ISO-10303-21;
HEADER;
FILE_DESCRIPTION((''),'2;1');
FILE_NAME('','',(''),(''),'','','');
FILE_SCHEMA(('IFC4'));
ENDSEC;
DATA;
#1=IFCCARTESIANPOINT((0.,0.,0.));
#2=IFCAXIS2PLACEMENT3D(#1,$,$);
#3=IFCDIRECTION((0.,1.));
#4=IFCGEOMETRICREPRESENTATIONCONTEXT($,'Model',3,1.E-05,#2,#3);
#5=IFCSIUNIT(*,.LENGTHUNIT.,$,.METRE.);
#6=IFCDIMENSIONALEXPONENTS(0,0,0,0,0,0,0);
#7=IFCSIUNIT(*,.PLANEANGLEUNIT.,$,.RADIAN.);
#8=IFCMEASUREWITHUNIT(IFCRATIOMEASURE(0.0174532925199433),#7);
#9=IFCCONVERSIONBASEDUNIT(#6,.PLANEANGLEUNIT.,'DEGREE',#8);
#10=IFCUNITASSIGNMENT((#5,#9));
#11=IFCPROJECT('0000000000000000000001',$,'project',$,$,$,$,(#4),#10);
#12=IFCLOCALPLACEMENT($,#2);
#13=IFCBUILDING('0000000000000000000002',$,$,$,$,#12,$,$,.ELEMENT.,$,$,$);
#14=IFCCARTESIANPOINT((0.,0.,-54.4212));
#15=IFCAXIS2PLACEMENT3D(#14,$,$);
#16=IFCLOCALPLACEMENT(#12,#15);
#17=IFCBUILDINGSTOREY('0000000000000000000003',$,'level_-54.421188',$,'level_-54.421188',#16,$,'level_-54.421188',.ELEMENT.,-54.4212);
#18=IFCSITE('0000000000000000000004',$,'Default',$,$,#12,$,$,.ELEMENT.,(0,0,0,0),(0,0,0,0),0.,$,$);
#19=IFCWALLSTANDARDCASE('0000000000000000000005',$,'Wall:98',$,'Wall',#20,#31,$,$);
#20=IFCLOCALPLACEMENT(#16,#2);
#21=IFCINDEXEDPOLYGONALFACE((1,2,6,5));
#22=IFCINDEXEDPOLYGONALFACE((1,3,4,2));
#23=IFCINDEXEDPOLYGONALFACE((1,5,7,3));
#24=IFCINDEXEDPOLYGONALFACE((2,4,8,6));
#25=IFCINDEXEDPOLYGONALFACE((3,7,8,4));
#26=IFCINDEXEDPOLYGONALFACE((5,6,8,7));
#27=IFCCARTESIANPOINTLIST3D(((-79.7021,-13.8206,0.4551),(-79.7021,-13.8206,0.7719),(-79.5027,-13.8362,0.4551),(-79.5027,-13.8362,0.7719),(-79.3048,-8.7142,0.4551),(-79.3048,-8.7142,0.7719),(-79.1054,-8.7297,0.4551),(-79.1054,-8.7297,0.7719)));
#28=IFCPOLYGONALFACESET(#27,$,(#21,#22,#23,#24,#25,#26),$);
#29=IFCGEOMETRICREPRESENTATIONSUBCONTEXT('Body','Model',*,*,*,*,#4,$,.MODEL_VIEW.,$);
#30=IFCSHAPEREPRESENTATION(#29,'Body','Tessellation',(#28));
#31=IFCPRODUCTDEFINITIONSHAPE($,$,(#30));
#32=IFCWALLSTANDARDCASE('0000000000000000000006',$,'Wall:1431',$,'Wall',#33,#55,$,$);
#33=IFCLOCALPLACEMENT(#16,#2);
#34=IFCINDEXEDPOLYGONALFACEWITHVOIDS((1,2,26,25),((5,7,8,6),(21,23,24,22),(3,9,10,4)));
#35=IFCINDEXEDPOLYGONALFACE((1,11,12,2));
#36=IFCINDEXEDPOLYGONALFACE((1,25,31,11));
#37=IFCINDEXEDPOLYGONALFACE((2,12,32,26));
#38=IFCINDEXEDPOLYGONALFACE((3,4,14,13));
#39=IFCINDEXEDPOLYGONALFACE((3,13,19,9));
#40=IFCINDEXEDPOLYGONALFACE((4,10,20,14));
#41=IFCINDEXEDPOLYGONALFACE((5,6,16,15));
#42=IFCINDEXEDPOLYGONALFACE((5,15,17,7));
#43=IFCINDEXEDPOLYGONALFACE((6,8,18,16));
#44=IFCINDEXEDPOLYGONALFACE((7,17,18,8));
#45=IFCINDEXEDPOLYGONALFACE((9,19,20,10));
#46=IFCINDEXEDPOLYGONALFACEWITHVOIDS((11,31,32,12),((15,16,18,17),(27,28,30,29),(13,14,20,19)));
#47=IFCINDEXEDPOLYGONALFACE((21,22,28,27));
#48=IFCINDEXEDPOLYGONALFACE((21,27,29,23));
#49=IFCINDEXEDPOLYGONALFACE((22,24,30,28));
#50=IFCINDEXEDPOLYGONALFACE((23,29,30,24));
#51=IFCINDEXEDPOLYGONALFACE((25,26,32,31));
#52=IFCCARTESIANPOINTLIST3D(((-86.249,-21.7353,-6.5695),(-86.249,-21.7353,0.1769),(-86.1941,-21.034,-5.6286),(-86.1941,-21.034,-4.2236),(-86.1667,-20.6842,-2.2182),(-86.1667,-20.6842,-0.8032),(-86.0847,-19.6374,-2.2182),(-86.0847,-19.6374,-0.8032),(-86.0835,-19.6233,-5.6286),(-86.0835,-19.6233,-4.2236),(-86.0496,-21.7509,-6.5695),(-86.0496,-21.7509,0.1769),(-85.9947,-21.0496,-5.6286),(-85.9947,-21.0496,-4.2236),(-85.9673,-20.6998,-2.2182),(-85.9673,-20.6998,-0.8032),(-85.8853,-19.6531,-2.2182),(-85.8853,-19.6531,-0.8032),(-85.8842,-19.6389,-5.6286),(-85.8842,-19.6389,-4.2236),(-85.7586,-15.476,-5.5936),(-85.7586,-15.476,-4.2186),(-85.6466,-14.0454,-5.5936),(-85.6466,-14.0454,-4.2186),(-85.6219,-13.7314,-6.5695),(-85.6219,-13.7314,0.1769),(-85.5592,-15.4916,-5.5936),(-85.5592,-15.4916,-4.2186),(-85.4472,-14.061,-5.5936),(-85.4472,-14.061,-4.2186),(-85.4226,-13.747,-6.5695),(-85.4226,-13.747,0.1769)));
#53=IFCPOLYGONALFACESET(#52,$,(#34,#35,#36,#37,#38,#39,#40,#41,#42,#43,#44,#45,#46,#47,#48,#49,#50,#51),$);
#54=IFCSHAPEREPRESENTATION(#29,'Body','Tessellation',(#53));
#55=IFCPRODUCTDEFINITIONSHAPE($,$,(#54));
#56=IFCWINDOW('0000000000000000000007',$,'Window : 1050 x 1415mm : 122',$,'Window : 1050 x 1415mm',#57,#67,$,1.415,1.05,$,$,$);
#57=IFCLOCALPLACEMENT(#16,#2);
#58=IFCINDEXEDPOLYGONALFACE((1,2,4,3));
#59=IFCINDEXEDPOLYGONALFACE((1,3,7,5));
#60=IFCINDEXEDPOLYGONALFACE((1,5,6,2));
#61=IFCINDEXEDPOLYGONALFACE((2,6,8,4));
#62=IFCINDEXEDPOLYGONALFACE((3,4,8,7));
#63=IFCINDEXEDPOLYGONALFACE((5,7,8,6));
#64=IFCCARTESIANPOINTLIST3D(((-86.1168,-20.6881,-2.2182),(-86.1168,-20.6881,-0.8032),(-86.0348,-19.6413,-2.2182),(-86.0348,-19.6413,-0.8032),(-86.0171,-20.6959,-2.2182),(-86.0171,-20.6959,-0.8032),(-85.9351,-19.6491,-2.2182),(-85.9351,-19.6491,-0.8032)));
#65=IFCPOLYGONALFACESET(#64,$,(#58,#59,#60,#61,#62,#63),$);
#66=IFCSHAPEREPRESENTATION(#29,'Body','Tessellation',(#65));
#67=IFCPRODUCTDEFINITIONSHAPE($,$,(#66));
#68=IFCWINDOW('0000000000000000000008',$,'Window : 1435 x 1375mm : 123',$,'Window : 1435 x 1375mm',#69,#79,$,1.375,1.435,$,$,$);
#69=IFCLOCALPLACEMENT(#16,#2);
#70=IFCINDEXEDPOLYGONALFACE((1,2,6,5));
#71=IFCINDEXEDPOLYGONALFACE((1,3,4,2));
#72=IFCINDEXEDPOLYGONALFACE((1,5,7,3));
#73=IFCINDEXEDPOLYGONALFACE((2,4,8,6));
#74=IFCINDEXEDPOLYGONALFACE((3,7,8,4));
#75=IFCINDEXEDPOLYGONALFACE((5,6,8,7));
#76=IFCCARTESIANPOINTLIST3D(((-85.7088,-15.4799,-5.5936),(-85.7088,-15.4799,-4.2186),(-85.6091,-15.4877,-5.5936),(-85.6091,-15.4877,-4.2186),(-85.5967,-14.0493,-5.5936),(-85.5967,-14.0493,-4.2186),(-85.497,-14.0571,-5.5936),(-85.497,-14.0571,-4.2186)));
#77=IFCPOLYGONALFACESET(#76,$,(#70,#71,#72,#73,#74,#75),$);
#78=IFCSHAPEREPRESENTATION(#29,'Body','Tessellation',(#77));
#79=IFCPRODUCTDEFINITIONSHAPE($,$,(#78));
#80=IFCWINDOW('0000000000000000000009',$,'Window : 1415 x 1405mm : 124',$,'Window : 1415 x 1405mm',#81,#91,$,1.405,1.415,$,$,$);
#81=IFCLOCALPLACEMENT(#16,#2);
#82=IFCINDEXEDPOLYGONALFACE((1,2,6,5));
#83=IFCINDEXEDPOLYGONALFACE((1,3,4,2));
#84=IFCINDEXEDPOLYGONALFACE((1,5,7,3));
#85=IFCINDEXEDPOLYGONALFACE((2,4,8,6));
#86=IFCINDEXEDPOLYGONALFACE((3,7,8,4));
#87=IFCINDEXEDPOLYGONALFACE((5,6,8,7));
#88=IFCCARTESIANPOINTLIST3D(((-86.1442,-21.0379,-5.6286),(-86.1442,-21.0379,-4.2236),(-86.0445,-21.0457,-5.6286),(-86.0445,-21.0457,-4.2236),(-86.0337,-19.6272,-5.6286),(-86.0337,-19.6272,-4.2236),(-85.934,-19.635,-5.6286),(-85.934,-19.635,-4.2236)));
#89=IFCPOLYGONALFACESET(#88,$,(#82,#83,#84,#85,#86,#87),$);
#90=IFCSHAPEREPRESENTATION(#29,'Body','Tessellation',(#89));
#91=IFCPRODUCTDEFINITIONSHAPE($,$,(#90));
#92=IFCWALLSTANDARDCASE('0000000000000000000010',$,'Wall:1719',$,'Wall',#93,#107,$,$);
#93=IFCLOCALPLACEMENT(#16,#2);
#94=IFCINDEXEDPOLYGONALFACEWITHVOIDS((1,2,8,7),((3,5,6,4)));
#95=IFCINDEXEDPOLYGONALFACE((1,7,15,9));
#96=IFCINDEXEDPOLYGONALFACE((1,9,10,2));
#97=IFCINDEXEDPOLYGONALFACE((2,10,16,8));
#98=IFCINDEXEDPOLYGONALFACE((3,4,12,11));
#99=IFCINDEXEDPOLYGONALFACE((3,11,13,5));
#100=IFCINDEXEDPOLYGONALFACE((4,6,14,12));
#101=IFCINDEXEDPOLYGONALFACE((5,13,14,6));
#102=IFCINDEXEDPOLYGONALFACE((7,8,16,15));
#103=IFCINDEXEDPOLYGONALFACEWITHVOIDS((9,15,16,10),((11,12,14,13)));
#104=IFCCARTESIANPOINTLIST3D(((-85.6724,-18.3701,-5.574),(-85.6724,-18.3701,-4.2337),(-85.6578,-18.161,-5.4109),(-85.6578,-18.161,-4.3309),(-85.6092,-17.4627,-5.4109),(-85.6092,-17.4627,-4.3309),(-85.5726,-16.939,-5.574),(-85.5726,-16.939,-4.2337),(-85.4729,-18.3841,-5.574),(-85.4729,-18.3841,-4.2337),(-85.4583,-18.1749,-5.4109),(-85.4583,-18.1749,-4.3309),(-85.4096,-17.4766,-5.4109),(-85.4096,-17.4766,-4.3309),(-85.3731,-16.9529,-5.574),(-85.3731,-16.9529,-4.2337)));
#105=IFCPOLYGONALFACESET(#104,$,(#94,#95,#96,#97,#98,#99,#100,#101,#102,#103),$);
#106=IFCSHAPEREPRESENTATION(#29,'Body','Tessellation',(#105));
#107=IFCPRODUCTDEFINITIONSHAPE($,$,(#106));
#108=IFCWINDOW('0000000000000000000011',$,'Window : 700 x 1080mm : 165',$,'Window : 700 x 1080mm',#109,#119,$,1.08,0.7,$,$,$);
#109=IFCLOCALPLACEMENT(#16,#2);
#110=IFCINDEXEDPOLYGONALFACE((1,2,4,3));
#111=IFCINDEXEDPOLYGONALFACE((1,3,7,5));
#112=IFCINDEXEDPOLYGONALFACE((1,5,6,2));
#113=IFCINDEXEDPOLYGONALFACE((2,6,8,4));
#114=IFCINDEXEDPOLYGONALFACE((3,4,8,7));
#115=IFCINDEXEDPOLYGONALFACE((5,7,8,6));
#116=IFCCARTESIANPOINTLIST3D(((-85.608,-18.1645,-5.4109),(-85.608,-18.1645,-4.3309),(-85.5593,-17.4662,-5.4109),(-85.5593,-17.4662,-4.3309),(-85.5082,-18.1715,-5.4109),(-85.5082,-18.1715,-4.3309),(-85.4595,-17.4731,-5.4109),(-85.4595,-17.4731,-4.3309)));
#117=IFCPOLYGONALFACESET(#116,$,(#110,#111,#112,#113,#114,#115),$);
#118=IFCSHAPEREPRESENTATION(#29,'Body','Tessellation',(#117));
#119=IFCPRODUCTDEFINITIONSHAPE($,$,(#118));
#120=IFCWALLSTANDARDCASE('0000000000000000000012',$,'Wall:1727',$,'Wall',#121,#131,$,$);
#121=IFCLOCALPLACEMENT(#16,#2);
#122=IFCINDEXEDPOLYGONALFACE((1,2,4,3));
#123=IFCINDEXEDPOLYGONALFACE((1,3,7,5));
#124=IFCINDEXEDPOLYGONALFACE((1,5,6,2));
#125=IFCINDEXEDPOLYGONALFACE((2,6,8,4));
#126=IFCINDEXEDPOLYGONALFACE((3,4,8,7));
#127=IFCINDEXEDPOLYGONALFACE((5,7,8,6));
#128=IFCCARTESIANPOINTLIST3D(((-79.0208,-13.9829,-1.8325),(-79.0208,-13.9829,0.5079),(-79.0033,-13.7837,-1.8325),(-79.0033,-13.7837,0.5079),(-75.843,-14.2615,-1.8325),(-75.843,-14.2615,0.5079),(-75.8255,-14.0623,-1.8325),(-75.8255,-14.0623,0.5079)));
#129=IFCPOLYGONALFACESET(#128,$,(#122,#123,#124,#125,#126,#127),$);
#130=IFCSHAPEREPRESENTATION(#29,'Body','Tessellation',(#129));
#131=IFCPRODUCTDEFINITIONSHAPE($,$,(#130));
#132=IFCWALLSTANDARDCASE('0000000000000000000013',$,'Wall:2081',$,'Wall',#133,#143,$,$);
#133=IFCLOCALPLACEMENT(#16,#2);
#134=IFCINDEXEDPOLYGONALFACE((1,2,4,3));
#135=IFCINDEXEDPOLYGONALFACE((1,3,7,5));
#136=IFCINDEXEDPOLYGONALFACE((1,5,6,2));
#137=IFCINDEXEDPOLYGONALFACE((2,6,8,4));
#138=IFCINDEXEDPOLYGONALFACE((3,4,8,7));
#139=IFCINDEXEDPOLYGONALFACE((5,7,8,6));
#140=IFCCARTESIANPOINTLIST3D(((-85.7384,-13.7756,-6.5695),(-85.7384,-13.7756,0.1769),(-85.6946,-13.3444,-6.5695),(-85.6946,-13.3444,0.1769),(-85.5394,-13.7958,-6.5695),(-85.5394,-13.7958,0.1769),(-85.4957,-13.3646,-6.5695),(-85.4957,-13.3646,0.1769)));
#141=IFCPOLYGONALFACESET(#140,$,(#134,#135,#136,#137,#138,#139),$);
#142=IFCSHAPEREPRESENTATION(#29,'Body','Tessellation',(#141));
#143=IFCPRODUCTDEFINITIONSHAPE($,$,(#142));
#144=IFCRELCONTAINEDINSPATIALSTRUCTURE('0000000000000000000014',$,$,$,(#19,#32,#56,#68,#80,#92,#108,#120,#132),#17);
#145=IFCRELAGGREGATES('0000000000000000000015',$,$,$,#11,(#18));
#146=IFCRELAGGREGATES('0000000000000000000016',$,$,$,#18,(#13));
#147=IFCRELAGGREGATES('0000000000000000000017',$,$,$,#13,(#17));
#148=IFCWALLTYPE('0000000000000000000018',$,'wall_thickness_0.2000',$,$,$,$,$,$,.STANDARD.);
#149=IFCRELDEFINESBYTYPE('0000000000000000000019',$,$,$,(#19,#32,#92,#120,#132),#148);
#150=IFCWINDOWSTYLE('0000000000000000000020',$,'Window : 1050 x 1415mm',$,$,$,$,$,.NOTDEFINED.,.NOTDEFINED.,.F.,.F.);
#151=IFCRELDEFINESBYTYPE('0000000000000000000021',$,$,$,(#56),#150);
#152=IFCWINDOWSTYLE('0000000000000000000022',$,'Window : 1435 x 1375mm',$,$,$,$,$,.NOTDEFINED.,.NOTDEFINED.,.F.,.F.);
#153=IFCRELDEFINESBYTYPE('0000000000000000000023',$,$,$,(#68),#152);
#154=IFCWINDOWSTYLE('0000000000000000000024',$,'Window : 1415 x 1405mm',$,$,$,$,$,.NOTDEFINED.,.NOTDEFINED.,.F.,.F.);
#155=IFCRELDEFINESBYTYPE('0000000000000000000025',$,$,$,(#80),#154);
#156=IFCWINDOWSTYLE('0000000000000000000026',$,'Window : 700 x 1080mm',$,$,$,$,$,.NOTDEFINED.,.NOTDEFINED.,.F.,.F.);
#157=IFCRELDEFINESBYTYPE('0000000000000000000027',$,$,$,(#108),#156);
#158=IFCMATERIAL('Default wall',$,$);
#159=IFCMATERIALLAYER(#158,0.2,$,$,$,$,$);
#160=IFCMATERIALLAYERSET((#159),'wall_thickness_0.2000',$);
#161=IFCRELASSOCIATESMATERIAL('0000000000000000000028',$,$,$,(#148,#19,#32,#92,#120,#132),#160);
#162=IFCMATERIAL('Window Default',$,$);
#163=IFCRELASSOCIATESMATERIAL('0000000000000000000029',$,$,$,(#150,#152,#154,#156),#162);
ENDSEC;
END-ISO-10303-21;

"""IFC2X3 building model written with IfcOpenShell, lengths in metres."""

from ifc_helpers import new_model, entity, si_unit, converted_unit, direction, frame, frame_2d, origin, origin_2d_with_axis, place, context, subcontext, project, spatial, polyline, rectangle, outline, extrude, source, transform, mapped, material, layer, layer_set, layer_usage, type_object, type_shapes, element, fill, save


model = new_model("IFC2X3")

# Units and contexts
model_context = context("Model", 3, precision=1e-05, world=origin(), true_north=direction((0.0, 1.0)))
body_context = subcontext(model_context, "Body", "Model", "MODEL_VIEW")
ifc_project = project(units=[si_unit("LENGTHUNIT", "METRE"), converted_unit("PLANEANGLEUNIT", "DEGREE", entity("IfcRatioMeasure", 0.0174532925199433), si_unit("PLANEANGLEUNIT", "RADIAN"), dimensions=[0, 0, 0, 0, 0, 0, 0])], contexts=[model_context])

# Site, building, storey
placement_1 = place(None, origin())
site = spatial("IfcSite", under=ifc_project, at=placement_1, Name="Default", CompositionType="ELEMENT", RefLatitude=(0, 0, 0, 0), RefLongitude=(0, 0, 0, 0), RefElevation=0.0)
building = spatial("IfcBuilding", under=site, at=placement_1, CompositionType="ELEMENT")
storey_placement = place(placement_1, frame((0.0, 0.0, -54.4212)))
storey = spatial("IfcBuildingStorey", under=building, at=storey_placement, Name="level_-54.421188", ObjectType="level_-54.421188", LongName="level_-54.421188", CompositionType="ELEMENT", Elevation=-54.4212)

# Wall
ifc_material_1 = material(Name="Default wall")
ifc_layer = layer(ifc_material_1, 0.2)
ifc_layer_set = layer_set([ifc_layer], Name="wall_thickness_0.2000")
ifc_layer_usage = layer_usage(ifc_layer_set, "AXIS2", "POSITIVE", -0.1)
wall_type = type_object("IfcWallType", Name="wall_thickness_0.2000", PredefinedType="STANDARD", material=ifc_layer_set)
placement_2 = place(placement_1, frame((0.0, 0.0, -53.9661)))
wall_1_placement = place(placement_2, frame((-79.6024, -13.8284, 0.0), z_axis=(0.0, 0.0, 1.0), x_axis=(0.077568, 0.996987, 0.0)))
element("IfcWallStandardCase", 1, at=wall_1_placement, inside=storey, type_object=wall_type, material=ifc_layer_usage, Name="Wall:98", ObjectType="Wall", context=body_context, shape_type="SweptSolid", body=[
    extrude(outline(polyline([(5.1219, -0.1), (5.1219, 0.1), (0.0, 0.1), (0.0, -0.1), (5.1219, -0.1)])), origin(), (0.0, 0.0, 1.0), 0.3169),
])

# Wall, openings, windows
placement_3 = place(placement_1, frame((0.0, 0.0, -60.9907)))
wall_2_placement = place(placement_3, frame((-85.5223, -13.7392, 0.0), z_axis=(0.0, 0.0, 1.0), x_axis=(-0.078105, -0.996945, 0.0)))
wall_2 = element("IfcWallStandardCase", 2, at=wall_2_placement, inside=storey, type_object=wall_type, material=ifc_layer_usage, Name="Wall:1431", ObjectType="Wall", context=body_context, shape_type="SweptSolid", body=[
    extrude(outline(polyline([(8.0285, -0.1), (8.0285, 0.1), (0.0, 0.1), (0.0, -0.1), (8.0285, -0.1)])), origin(), (0.0, 0.0, 1.0), 6.7464),
])
opening_1_placement = place(wall_2_placement, frame((5.9242, -0.1, 4.3512)))
opening_1 = element("IfcOpeningElement", 3, at=opening_1_placement, cuts=wall_2, ObjectType="Opening", context=body_context, shape_type="SweptSolid", body=[
    extrude(rectangle(XDim=1.05, YDim=1.415, at=frame_2d((0.7075, 0.525), x_axis=(0.0, 1.0))), frame((0.0, 0.0, 0.0), z_axis=(0.0, 1.0, 0.0), x_axis=(0.0, 0.0, 1.0)), (0.0, 0.0, 1.0), 0.2),
])
opening_2_placement = place(wall_2_placement, frame((0.315, -0.1, 0.9759)))
opening_2 = element("IfcOpeningElement", 4, at=opening_2_placement, cuts=wall_2, ObjectType="Opening", context=body_context, shape_type="SweptSolid", body=[
    extrude(rectangle(XDim=1.435, YDim=1.375, at=frame_2d((0.6875, 0.7175), x_axis=(0.0, 1.0))), frame((0.0, 0.0, 0.0), z_axis=(0.0, 1.0, 0.0), x_axis=(0.0, 0.0, 1.0)), (0.0, 0.0, 1.0), 0.2),
])
opening_3_placement = place(wall_2_placement, frame((5.91, -0.1, 0.9409)))
opening_3 = element("IfcOpeningElement", 5, at=opening_3_placement, cuts=wall_2, ObjectType="Opening", context=body_context, shape_type="SweptSolid", body=[
    extrude(rectangle(XDim=1.415, YDim=1.405, at=frame_2d((0.7025, 0.7075), x_axis=(0.0, 1.0))), frame((0.0, 0.0, 0.0), z_axis=(0.0, 1.0, 0.0), x_axis=(0.0, 0.0, 1.0)), (0.0, 0.0, 1.0), 0.2),
])
ifc_material_2 = material(Name="Window Default")
window_style_1 = type_object("IfcWindowStyle", Name="Window : 1050 x 1415mm", ConstructionType="NOTDEFINED", OperationType="NOTDEFINED", ParameterTakesPrecedence=False, Sizeable=False, material=ifc_material_2)
shared_shape_1 = source(origin(), body_context, "Body", "SweptSolid", [
    extrude(rectangle(XDim=0.1, YDim=1.05, at=origin_2d_with_axis()), frame((0.525, 0.1, 0.0), z_axis=(0.0, 0.0, 1.0), x_axis=(0.0, 1.0, 0.0)), (0.0, 0.0, 1.0), 1.415),
])
type_shapes(window_style_1, [shared_shape_1])
window_1_placement = place(opening_1_placement, origin())
window_1 = element("IfcWindow", 6, at=window_1_placement, inside=storey, type_object=window_style_1, Name="Window : 1050 x 1415mm : 122", ObjectType="Window : 1050 x 1415mm", OverallHeight=1.415, OverallWidth=1.05, context=body_context, shape_type="MappedRepresentation", body=[
    mapped(shared_shape_1, transform((0.0, 0.0, 0.0), scale=1.0)),
])
fill(opening_1, window_1)
window_style_2 = type_object("IfcWindowStyle", Name="Window : 1435 x 1375mm", ConstructionType="NOTDEFINED", OperationType="NOTDEFINED", ParameterTakesPrecedence=False, Sizeable=False, material=ifc_material_2)
shared_shape_2 = source(origin(), body_context, "Body", "SweptSolid", [
    extrude(rectangle(XDim=0.1, YDim=1.435, at=origin_2d_with_axis()), frame((0.7175, 0.1, 0.0), z_axis=(0.0, 0.0, 1.0), x_axis=(0.0, 1.0, 0.0)), (0.0, 0.0, 1.0), 1.375),
])
type_shapes(window_style_2, [shared_shape_2])
window_2_placement = place(opening_2_placement, origin())
window_2 = element("IfcWindow", 7, at=window_2_placement, inside=storey, type_object=window_style_2, Name="Window : 1435 x 1375mm : 123", ObjectType="Window : 1435 x 1375mm", OverallHeight=1.375, OverallWidth=1.435, context=body_context, shape_type="MappedRepresentation", body=[
    mapped(shared_shape_2, transform((0.0, 0.0, 0.0), scale=1.0)),
])
fill(opening_2, window_2)
window_style_3 = type_object("IfcWindowStyle", Name="Window : 1415 x 1405mm", ConstructionType="NOTDEFINED", OperationType="NOTDEFINED", ParameterTakesPrecedence=False, Sizeable=False, material=ifc_material_2)
shared_shape_3 = source(origin(), body_context, "Body", "SweptSolid", [
    extrude(rectangle(XDim=0.1, YDim=1.415, at=origin_2d_with_axis()), frame((0.7075, 0.1, 0.0), z_axis=(0.0, 0.0, 1.0), x_axis=(0.0, 1.0, 0.0)), (0.0, 0.0, 1.0), 1.405),
])
type_shapes(window_style_3, [shared_shape_3])
window_3_placement = place(opening_3_placement, origin())
window_3 = element("IfcWindow", 8, at=window_3_placement, inside=storey, type_object=window_style_3, Name="Window : 1415 x 1405mm : 124", ObjectType="Window : 1415 x 1405mm", OverallHeight=1.405, OverallWidth=1.415, context=body_context, shape_type="MappedRepresentation", body=[
    mapped(shared_shape_3, transform((0.0, 0.0, 0.0), scale=1.0)),
])
fill(opening_3, window_3)

# Wall, opening, window
placement_4 = place(placement_1, frame((0.0, 0.0, -59.9952)))
wall_3_placement = place(placement_4, frame((-85.4729, -16.9459, 0.0), z_axis=(0.0, 0.0, 1.0), x_axis=(-0.069565, -0.997577, 0.0)))
wall_3 = element("IfcWallStandardCase", 9, at=wall_3_placement, inside=storey, type_object=wall_type, material=ifc_layer_usage, Name="Wall:1719", ObjectType="Wall", context=body_context, shape_type="SweptSolid", body=[
    extrude(outline(polyline([(1.4346, -0.1), (1.4346, 0.1), (0.0, 0.1), (0.0, -0.1), (1.4346, -0.1)])), origin(), (0.0, 0.0, 1.0), 1.3402),
])
opening_4_placement = place(wall_3_placement, frame((0.525, -0.1, 0.1631)))
opening_4 = element("IfcOpeningElement", 10, at=opening_4_placement, cuts=wall_3, ObjectType="Opening", context=body_context, shape_type="SweptSolid", body=[
    extrude(rectangle(XDim=0.7, YDim=1.08, at=frame_2d((0.54, 0.35), x_axis=(0.0, 1.0))), frame((0.0, 0.0, 0.0), z_axis=(0.0, 1.0, 0.0), x_axis=(0.0, 0.0, 1.0)), (0.0, 0.0, 1.0), 0.2),
])
window_style_4 = type_object("IfcWindowStyle", Name="Window : 700 x 1080mm", ConstructionType="NOTDEFINED", OperationType="NOTDEFINED", ParameterTakesPrecedence=False, Sizeable=False, material=ifc_material_2)
shared_shape_4 = source(origin(), body_context, "Body", "SweptSolid", [
    extrude(rectangle(XDim=0.1, YDim=0.7, at=origin_2d_with_axis()), frame((0.35, 0.1, 0.0), z_axis=(0.0, 0.0, 1.0), x_axis=(0.0, 1.0, 0.0)), (0.0, 0.0, 1.0), 1.08),
])
type_shapes(window_style_4, [shared_shape_4])
window_4_placement = place(opening_4_placement, origin())
window_4 = element("IfcWindow", 11, at=window_4_placement, inside=storey, type_object=window_style_4, Name="Window : 700 x 1080mm : 165", ObjectType="Window : 700 x 1080mm", OverallHeight=1.08, OverallWidth=0.7, context=body_context, shape_type="MappedRepresentation", body=[
    mapped(shared_shape_4, transform((0.0, 0.0, 0.0), scale=1.0)),
])
fill(opening_4, window_4)

# Walls
placement_5 = place(placement_1, frame((0.0, 0.0, -56.2537)))
wall_4_placement = place(placement_5, frame((-79.0121, -13.8833, 0.0), z_axis=(0.0, 0.0, 1.0), x_axis=(0.996179, -0.087331, 0.0)))
element("IfcWallStandardCase", 12, at=wall_4_placement, inside=storey, type_object=wall_type, material=ifc_layer_usage, Name="Wall:1727", ObjectType="Wall", context=body_context, shape_type="SweptSolid", body=[
    extrude(outline(polyline([(3.19, -0.1), (3.19, 0.1), (0.0, 0.1), (0.0, -0.1), (3.19, -0.1)])), origin(), (0.0, 0.0, 1.0), 2.3404),
])
placement_6 = place(placement_1, frame((0.0, 0.0, -60.9907)))
wall_5_placement = place(placement_6, frame((-85.6389, -13.7857, 0.0), z_axis=(0.0, 0.0, 1.0), x_axis=(0.100935, 0.994893, 0.0)))
element("IfcWallStandardCase", 13, at=wall_5_placement, inside=storey, type_object=wall_type, material=ifc_layer_usage, Name="Wall:2081", ObjectType="Wall", context=body_context, shape_type="SweptSolid", body=[
    extrude(outline(polyline([(0.4334, -0.1), (0.4334, 0.1), (0.0, 0.1), (0.0, -0.1), (0.4334, -0.1)])), origin(), (0.0, 0.0, 1.0), 6.7464),
])

save(model, "model.ifc")
